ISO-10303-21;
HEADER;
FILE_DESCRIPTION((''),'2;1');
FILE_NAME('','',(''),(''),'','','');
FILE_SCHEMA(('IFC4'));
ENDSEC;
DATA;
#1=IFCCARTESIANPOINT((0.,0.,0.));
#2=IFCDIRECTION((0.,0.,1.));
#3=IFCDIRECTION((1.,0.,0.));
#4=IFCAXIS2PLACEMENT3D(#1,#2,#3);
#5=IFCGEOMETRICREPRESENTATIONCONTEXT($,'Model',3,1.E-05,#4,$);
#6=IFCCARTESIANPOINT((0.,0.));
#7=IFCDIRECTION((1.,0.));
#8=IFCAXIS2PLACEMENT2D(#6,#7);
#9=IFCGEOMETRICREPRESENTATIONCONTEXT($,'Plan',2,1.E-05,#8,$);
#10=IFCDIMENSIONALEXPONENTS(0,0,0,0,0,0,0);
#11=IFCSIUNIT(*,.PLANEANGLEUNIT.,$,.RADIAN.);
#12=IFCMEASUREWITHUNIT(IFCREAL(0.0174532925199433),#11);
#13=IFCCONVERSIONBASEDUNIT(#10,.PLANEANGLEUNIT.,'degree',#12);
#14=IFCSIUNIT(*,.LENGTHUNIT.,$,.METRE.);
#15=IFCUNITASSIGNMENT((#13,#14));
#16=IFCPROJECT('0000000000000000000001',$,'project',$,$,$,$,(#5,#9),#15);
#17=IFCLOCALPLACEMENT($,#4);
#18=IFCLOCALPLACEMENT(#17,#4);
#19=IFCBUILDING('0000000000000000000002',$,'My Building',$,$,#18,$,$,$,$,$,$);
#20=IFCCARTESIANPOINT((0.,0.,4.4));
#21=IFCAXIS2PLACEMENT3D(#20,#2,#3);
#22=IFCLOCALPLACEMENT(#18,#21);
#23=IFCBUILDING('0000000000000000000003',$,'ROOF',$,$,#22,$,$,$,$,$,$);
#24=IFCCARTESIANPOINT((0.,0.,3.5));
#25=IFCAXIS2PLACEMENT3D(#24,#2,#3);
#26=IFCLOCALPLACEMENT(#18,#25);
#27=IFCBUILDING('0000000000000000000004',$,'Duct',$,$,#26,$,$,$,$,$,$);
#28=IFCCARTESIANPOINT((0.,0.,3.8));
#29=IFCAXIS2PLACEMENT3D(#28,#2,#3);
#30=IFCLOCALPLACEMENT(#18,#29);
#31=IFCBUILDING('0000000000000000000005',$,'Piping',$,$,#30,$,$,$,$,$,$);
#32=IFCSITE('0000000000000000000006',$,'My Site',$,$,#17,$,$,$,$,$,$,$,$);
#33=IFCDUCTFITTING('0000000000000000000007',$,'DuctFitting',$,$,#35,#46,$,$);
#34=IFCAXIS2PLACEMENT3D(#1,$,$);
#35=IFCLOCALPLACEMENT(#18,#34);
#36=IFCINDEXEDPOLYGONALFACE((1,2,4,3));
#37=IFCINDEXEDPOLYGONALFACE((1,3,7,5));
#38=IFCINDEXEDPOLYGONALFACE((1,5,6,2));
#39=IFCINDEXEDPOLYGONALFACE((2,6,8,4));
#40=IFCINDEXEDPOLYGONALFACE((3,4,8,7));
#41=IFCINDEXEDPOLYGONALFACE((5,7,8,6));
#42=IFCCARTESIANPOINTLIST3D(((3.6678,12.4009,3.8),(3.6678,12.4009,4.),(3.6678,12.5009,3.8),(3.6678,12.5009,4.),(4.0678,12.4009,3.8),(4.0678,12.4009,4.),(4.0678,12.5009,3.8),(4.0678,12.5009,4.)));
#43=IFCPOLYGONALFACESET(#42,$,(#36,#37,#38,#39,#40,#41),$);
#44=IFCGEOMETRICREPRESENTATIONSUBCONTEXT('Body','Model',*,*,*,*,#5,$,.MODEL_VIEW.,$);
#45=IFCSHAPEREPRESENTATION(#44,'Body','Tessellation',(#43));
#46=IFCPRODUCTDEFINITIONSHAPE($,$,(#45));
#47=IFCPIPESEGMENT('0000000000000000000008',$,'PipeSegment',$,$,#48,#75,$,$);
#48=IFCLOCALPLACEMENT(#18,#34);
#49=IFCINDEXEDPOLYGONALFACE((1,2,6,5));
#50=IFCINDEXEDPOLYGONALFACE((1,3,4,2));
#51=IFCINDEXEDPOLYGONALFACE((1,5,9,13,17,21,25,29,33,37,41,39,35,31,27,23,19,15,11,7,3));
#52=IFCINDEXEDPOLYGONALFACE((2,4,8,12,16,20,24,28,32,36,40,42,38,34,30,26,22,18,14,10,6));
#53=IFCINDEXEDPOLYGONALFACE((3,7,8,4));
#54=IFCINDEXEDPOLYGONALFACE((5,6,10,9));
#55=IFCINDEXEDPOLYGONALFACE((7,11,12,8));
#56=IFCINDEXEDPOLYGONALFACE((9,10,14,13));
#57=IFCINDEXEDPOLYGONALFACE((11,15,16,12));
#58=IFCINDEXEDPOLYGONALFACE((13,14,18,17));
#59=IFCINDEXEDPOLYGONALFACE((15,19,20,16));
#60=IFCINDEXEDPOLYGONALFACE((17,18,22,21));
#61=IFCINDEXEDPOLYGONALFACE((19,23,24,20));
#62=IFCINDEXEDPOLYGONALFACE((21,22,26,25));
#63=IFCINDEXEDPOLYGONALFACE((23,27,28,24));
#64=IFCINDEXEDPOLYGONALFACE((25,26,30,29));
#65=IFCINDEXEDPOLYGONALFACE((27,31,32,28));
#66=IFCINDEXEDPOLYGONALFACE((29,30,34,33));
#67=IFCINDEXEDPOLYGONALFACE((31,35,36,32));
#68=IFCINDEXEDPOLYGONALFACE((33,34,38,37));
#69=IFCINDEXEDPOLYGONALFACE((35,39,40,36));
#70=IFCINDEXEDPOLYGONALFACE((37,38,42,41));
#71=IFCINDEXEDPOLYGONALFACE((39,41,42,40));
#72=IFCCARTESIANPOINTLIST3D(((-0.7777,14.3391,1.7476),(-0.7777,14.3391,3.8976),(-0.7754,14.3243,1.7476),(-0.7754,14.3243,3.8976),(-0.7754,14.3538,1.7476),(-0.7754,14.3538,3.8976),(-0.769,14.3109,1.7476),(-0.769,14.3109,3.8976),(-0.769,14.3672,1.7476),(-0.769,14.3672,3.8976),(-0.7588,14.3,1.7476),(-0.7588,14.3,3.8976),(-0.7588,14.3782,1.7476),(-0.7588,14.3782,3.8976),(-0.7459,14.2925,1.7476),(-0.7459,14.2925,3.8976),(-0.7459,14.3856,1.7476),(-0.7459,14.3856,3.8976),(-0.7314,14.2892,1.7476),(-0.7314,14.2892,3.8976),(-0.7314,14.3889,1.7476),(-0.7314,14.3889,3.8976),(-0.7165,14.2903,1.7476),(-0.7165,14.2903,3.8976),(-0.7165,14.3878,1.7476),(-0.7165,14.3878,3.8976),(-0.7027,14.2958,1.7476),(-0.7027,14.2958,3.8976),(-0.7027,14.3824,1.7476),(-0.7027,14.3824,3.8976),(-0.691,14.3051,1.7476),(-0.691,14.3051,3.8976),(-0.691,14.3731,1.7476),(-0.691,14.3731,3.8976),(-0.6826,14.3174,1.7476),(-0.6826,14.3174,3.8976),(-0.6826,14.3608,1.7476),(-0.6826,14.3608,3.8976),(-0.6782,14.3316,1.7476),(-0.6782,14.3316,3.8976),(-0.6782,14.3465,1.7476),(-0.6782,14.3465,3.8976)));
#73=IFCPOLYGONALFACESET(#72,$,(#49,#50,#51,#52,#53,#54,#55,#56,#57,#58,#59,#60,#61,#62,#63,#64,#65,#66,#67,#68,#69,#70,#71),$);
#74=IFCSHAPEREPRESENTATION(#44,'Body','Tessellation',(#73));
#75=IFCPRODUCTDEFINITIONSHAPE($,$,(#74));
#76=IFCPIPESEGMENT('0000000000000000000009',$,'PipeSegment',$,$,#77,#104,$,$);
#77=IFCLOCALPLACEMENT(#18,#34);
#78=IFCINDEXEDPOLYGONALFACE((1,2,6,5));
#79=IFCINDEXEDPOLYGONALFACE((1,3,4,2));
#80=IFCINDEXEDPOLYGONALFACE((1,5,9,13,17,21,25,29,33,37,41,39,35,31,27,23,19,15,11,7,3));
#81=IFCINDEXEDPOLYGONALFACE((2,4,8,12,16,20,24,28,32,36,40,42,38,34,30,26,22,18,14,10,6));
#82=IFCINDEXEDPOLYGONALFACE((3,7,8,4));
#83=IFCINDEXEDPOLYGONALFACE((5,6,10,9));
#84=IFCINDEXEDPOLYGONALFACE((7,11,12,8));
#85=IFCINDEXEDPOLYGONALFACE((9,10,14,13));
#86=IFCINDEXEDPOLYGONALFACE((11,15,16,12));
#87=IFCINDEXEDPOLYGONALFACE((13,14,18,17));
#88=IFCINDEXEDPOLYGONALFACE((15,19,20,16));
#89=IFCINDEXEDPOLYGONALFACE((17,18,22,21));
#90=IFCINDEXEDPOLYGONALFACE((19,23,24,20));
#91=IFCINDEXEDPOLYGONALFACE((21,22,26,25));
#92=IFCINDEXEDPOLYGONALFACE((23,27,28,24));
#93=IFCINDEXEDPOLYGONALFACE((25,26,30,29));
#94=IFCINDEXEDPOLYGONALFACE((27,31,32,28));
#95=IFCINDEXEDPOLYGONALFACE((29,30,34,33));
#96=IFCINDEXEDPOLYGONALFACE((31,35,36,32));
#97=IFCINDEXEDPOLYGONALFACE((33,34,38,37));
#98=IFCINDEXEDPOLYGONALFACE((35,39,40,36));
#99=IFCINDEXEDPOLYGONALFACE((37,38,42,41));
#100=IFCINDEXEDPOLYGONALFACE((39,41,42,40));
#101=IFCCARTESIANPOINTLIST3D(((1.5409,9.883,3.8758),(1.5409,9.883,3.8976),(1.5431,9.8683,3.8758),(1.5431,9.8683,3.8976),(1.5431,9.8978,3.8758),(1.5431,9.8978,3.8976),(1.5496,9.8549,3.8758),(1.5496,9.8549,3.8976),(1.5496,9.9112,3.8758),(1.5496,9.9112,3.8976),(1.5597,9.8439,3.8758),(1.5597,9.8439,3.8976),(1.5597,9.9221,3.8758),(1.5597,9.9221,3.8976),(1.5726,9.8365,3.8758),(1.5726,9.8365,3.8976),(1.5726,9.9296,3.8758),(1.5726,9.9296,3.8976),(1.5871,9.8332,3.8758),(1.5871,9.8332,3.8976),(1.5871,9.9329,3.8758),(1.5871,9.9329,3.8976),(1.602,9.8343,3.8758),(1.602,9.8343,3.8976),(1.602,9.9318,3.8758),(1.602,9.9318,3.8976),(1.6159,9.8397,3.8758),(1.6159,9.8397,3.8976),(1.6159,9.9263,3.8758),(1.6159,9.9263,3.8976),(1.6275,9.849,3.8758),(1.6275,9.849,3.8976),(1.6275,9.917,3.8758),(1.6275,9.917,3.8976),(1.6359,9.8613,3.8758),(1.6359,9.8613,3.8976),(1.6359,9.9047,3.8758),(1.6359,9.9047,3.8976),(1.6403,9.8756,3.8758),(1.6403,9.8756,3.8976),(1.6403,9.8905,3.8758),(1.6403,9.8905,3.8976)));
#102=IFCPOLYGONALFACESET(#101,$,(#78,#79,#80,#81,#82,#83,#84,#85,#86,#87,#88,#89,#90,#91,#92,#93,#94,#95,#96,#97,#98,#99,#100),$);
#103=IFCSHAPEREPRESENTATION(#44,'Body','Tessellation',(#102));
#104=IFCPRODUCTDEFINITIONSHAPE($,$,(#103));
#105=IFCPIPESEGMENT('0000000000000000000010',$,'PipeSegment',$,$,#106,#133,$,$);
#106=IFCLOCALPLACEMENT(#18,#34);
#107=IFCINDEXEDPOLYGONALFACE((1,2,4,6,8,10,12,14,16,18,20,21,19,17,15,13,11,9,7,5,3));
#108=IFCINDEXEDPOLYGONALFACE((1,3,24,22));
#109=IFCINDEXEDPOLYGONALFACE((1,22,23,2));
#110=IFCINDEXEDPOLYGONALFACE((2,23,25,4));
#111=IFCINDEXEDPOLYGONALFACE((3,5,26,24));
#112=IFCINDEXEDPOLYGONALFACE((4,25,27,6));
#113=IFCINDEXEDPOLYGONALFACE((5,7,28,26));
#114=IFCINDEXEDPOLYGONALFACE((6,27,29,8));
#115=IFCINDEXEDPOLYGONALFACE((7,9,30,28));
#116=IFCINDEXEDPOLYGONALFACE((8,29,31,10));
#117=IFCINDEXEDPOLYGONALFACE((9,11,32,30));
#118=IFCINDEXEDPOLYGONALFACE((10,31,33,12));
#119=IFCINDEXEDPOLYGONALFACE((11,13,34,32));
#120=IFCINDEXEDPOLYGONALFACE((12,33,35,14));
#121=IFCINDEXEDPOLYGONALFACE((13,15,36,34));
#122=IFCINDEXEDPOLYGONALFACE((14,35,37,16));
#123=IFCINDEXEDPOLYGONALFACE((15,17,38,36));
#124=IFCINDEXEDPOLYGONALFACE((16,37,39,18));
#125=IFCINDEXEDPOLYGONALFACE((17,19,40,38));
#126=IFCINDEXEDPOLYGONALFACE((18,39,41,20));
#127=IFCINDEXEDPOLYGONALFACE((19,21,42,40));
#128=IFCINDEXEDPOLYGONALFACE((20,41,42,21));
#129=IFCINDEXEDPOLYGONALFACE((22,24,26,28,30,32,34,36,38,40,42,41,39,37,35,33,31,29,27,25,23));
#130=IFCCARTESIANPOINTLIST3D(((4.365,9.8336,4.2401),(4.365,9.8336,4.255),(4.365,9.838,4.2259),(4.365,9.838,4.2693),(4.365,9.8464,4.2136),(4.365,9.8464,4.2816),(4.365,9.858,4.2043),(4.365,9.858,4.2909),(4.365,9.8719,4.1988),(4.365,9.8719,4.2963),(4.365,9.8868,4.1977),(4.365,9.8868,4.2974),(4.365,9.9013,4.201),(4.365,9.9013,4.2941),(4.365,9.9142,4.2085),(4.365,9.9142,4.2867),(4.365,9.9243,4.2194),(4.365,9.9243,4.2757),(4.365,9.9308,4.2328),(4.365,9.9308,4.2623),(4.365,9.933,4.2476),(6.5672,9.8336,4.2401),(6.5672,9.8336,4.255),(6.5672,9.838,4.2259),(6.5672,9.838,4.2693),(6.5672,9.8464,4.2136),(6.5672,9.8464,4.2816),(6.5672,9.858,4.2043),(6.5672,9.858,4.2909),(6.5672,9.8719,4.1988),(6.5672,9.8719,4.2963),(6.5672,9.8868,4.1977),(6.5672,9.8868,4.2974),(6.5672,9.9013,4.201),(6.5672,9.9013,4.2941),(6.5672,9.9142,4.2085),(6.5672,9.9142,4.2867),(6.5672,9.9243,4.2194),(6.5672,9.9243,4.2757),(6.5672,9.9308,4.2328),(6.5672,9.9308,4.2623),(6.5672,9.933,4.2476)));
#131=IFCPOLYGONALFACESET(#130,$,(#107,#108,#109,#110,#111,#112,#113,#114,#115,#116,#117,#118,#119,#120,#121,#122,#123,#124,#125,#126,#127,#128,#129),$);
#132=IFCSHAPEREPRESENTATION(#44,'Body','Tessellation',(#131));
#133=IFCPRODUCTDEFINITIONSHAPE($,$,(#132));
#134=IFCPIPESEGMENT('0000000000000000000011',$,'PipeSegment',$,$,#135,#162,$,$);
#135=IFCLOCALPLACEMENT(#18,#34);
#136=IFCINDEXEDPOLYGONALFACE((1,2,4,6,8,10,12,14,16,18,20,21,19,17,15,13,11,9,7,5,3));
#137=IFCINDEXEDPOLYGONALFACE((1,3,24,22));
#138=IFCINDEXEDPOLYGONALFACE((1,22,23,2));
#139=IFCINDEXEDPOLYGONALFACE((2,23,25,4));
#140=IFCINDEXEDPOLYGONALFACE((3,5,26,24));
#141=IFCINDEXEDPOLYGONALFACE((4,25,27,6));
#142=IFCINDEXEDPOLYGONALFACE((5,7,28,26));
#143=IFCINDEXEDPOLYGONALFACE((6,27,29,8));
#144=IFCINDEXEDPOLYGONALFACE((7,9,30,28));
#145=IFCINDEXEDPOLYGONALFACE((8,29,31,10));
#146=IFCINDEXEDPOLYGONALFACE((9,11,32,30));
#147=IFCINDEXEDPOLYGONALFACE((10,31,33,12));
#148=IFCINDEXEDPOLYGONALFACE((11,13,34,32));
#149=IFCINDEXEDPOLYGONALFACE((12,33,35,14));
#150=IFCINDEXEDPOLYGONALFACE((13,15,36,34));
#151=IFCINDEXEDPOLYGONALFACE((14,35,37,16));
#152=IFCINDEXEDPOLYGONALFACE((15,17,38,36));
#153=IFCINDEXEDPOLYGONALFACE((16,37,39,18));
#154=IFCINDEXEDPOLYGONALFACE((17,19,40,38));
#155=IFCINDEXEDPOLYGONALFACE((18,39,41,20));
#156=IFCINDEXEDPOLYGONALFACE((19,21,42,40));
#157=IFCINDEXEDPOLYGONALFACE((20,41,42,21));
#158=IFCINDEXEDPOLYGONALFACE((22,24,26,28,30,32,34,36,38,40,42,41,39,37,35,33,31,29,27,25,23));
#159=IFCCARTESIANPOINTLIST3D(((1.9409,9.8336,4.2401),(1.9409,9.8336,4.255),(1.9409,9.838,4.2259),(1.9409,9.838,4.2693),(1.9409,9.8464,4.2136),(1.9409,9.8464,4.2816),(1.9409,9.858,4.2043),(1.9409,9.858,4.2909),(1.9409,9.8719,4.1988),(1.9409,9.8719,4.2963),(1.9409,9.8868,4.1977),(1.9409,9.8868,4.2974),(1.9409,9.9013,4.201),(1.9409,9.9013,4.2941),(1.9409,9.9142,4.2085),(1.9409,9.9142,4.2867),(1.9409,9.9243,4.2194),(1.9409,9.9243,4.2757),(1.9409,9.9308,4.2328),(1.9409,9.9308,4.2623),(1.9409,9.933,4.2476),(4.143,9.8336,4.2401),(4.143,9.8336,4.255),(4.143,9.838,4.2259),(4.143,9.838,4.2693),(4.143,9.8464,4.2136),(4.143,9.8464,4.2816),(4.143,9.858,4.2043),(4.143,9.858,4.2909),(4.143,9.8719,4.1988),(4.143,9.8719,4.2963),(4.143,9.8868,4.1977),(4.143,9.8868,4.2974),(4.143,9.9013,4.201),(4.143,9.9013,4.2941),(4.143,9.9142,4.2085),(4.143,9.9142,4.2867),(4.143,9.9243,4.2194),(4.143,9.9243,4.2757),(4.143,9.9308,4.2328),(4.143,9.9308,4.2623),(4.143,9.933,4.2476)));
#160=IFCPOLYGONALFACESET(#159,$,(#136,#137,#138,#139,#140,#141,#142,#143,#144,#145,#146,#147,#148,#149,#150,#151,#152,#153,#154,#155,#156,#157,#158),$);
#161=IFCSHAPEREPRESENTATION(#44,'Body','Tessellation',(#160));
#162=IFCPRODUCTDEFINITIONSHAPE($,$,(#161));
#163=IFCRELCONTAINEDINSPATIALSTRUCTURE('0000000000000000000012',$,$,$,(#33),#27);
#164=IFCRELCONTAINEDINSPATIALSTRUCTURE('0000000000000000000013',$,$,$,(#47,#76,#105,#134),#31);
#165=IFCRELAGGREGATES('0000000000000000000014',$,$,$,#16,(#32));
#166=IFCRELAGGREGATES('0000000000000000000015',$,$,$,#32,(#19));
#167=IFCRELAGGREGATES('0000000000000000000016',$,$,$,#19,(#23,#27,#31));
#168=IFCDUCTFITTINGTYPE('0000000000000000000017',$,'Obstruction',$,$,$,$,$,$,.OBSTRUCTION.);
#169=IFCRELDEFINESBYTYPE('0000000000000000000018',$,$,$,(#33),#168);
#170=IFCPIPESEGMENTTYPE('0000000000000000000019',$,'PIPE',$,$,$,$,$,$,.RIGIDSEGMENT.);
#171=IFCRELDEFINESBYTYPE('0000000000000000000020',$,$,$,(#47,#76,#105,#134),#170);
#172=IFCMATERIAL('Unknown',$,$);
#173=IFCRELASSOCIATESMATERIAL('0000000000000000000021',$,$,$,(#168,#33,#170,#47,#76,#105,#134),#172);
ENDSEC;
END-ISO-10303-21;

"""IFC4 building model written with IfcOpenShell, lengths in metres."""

from ifc_helpers import new_model, entity, si_unit, converted_unit, frame, origin_with_axes, origin_2d_with_axis, place, context, subcontext, project, spatial, rectangle, circle, extrude, material, material_profile, profile_set, profile_usage, type_object, element, save


model = new_model("IFC4")

# Units and contexts
model_context = context("Model", 3, precision=1e-05, world=origin_with_axes())
plan_context = context("Plan", 2, precision=1e-05, world=origin_2d_with_axis())
body_context_1 = subcontext(model_context, "Body", "Model", "MODEL_VIEW")
ifc_project = project(units=[converted_unit("PLANEANGLEUNIT", "degree", entity("IfcReal", 0.0174532925199433), si_unit("PLANEANGLEUNIT", "RADIAN"), dimensions=[0, 0, 0, 0, 0, 0, 0]), si_unit("LENGTHUNIT", "METRE")], contexts=[model_context, plan_context])

# Site, building
site_placement = place(None, origin_with_axes())
site = spatial("IfcSite", under=ifc_project, at=site_placement, Name="My Site")
building_1_placement = place(site_placement, origin_with_axes())
building_1 = spatial("IfcBuilding", under=site, at=building_1_placement, Name="My Building")

# Shared definitions
ifc_material = material(Name="Unknown")

# Shared definitions
building_2_placement = place(building_1_placement, frame((0.0, 0.0, 4.4), z_axis=(0.0, 0.0, 1.0), x_axis=(1.0, 0.0, 0.0)))
building_2 = spatial("IfcBuilding", under=building_1, at=building_2_placement, Name="ROOF")

# Shared definitions
building_3_placement = place(building_1_placement, frame((0.0, 0.0, 3.5), z_axis=(0.0, 0.0, 1.0), x_axis=(1.0, 0.0, 0.0)))
building_3 = spatial("IfcBuilding", under=building_1, at=building_3_placement, Name="Duct")

# Duct fitting
ifc_material_profile_1 = material_profile(ifc_material, rectangle(XDim=0.4, YDim=0.2))
ifc_profile_set_1 = profile_set([ifc_material_profile_1])
ifc_profile_usage_1 = profile_usage(ifc_profile_set_1, cardinal=5)
duct_fitting_type_1 = type_object("IfcDuctFittingType", Name="Obstruction", PredefinedType="OBSTRUCTION", material=ifc_profile_set_1)
duct_fitting_1_placement = place(building_3_placement, frame((3.8678, 12.5009, 0.4), z_axis=(0.0, -1.0, 0.0), x_axis=(1.0, 0.0, 0.0)))
element("IfcDuctFitting", 1, at=duct_fitting_1_placement, inside=building_3, type_object=duct_fitting_type_1, material=ifc_profile_usage_1, Name="DuctFitting", context=body_context_1, shape_type="SweptSolid", body=[
    extrude(rectangle(XDim=0.4, YDim=0.2), origin_with_axes(), (0.0, 0.0, 1.0), 0.1),
])

# Shared definitions
building_4_placement = place(building_1_placement, frame((0.0, 0.0, 3.8), z_axis=(0.0, 0.0, 1.0), x_axis=(1.0, 0.0, 0.0)))
building_4 = spatial("IfcBuilding", under=building_1, at=building_4_placement, Name="Piping")

# Pipe segments
ifc_material_profile_2 = material_profile(ifc_material, circle(Radius=0.05))
ifc_profile_set_2 = profile_set([ifc_material_profile_2])
ifc_profile_usage_2 = profile_usage(ifc_profile_set_2, cardinal=5)
pipe_segment_type = type_object("IfcPipeSegmentType", Name="PIPE", PredefinedType="RIGIDSEGMENT", material=ifc_profile_set_2)
pipe_segment_1_placement = place(building_4_placement, frame((-0.7277, 14.3391, -2.0524), z_axis=(0.0, 0.0, 1.0), x_axis=(-1.0, 0.0, 0.0)))
element("IfcPipeSegment", 2, at=pipe_segment_1_placement, inside=building_4, type_object=pipe_segment_type, material=ifc_profile_usage_2, Name="PipeSegment", context=body_context_1, shape_type="SweptSolid", body=[
    extrude(circle(Radius=0.05), origin_with_axes(), (0.0, 0.0, 1.0), 2.15),
])
ifc_profile_usage_3 = profile_usage(ifc_profile_set_2, cardinal=5)
pipe_segment_2_placement = place(building_4_placement, frame((1.5909, 9.883, 0.0976), z_axis=(0.0, 0.0, -1.0), x_axis=(-1.0, 0.0, 0.0)))
element("IfcPipeSegment", 3, at=pipe_segment_2_placement, inside=building_4, type_object=pipe_segment_type, material=ifc_profile_usage_3, Name="PipeSegment", context=body_context_1, shape_type="SweptSolid", body=[
    extrude(circle(Radius=0.05), origin_with_axes(), (0.0, 0.0, 1.0), 0.0218),
])
ifc_profile_usage_4 = profile_usage(ifc_profile_set_2, cardinal=5)
pipe_segment_3_placement = place(building_4_placement, frame((4.365, 9.883, 0.4476), z_axis=(1.0, -0.000001, 0.000001), x_axis=(0.000001, 1.0, 0.0)))
element("IfcPipeSegment", 4, at=pipe_segment_3_placement, inside=building_4, type_object=pipe_segment_type, material=ifc_profile_usage_4, Name="PipeSegment", context=body_context_1, shape_type="SweptSolid", body=[
    extrude(circle(Radius=0.05), origin_with_axes(), (0.0, 0.0, 1.0), 2.2022),
])
ifc_profile_usage_5 = profile_usage(ifc_profile_set_2, cardinal=5)
pipe_segment_4_placement = place(building_4_placement, frame((4.143, 9.883, 0.4476), z_axis=(-1.0, -0.000001, -0.000001), x_axis=(-0.000001, 1.0, 0.0)))
element("IfcPipeSegment", 5, at=pipe_segment_4_placement, inside=building_4, type_object=pipe_segment_type, material=ifc_profile_usage_5, Name="PipeSegment", context=body_context_1, shape_type="SweptSolid", body=[
    extrude(circle(Radius=0.05), origin_with_axes(), (0.0, 0.0, 1.0), 2.2022),
])

save(model, "model.ifc")
